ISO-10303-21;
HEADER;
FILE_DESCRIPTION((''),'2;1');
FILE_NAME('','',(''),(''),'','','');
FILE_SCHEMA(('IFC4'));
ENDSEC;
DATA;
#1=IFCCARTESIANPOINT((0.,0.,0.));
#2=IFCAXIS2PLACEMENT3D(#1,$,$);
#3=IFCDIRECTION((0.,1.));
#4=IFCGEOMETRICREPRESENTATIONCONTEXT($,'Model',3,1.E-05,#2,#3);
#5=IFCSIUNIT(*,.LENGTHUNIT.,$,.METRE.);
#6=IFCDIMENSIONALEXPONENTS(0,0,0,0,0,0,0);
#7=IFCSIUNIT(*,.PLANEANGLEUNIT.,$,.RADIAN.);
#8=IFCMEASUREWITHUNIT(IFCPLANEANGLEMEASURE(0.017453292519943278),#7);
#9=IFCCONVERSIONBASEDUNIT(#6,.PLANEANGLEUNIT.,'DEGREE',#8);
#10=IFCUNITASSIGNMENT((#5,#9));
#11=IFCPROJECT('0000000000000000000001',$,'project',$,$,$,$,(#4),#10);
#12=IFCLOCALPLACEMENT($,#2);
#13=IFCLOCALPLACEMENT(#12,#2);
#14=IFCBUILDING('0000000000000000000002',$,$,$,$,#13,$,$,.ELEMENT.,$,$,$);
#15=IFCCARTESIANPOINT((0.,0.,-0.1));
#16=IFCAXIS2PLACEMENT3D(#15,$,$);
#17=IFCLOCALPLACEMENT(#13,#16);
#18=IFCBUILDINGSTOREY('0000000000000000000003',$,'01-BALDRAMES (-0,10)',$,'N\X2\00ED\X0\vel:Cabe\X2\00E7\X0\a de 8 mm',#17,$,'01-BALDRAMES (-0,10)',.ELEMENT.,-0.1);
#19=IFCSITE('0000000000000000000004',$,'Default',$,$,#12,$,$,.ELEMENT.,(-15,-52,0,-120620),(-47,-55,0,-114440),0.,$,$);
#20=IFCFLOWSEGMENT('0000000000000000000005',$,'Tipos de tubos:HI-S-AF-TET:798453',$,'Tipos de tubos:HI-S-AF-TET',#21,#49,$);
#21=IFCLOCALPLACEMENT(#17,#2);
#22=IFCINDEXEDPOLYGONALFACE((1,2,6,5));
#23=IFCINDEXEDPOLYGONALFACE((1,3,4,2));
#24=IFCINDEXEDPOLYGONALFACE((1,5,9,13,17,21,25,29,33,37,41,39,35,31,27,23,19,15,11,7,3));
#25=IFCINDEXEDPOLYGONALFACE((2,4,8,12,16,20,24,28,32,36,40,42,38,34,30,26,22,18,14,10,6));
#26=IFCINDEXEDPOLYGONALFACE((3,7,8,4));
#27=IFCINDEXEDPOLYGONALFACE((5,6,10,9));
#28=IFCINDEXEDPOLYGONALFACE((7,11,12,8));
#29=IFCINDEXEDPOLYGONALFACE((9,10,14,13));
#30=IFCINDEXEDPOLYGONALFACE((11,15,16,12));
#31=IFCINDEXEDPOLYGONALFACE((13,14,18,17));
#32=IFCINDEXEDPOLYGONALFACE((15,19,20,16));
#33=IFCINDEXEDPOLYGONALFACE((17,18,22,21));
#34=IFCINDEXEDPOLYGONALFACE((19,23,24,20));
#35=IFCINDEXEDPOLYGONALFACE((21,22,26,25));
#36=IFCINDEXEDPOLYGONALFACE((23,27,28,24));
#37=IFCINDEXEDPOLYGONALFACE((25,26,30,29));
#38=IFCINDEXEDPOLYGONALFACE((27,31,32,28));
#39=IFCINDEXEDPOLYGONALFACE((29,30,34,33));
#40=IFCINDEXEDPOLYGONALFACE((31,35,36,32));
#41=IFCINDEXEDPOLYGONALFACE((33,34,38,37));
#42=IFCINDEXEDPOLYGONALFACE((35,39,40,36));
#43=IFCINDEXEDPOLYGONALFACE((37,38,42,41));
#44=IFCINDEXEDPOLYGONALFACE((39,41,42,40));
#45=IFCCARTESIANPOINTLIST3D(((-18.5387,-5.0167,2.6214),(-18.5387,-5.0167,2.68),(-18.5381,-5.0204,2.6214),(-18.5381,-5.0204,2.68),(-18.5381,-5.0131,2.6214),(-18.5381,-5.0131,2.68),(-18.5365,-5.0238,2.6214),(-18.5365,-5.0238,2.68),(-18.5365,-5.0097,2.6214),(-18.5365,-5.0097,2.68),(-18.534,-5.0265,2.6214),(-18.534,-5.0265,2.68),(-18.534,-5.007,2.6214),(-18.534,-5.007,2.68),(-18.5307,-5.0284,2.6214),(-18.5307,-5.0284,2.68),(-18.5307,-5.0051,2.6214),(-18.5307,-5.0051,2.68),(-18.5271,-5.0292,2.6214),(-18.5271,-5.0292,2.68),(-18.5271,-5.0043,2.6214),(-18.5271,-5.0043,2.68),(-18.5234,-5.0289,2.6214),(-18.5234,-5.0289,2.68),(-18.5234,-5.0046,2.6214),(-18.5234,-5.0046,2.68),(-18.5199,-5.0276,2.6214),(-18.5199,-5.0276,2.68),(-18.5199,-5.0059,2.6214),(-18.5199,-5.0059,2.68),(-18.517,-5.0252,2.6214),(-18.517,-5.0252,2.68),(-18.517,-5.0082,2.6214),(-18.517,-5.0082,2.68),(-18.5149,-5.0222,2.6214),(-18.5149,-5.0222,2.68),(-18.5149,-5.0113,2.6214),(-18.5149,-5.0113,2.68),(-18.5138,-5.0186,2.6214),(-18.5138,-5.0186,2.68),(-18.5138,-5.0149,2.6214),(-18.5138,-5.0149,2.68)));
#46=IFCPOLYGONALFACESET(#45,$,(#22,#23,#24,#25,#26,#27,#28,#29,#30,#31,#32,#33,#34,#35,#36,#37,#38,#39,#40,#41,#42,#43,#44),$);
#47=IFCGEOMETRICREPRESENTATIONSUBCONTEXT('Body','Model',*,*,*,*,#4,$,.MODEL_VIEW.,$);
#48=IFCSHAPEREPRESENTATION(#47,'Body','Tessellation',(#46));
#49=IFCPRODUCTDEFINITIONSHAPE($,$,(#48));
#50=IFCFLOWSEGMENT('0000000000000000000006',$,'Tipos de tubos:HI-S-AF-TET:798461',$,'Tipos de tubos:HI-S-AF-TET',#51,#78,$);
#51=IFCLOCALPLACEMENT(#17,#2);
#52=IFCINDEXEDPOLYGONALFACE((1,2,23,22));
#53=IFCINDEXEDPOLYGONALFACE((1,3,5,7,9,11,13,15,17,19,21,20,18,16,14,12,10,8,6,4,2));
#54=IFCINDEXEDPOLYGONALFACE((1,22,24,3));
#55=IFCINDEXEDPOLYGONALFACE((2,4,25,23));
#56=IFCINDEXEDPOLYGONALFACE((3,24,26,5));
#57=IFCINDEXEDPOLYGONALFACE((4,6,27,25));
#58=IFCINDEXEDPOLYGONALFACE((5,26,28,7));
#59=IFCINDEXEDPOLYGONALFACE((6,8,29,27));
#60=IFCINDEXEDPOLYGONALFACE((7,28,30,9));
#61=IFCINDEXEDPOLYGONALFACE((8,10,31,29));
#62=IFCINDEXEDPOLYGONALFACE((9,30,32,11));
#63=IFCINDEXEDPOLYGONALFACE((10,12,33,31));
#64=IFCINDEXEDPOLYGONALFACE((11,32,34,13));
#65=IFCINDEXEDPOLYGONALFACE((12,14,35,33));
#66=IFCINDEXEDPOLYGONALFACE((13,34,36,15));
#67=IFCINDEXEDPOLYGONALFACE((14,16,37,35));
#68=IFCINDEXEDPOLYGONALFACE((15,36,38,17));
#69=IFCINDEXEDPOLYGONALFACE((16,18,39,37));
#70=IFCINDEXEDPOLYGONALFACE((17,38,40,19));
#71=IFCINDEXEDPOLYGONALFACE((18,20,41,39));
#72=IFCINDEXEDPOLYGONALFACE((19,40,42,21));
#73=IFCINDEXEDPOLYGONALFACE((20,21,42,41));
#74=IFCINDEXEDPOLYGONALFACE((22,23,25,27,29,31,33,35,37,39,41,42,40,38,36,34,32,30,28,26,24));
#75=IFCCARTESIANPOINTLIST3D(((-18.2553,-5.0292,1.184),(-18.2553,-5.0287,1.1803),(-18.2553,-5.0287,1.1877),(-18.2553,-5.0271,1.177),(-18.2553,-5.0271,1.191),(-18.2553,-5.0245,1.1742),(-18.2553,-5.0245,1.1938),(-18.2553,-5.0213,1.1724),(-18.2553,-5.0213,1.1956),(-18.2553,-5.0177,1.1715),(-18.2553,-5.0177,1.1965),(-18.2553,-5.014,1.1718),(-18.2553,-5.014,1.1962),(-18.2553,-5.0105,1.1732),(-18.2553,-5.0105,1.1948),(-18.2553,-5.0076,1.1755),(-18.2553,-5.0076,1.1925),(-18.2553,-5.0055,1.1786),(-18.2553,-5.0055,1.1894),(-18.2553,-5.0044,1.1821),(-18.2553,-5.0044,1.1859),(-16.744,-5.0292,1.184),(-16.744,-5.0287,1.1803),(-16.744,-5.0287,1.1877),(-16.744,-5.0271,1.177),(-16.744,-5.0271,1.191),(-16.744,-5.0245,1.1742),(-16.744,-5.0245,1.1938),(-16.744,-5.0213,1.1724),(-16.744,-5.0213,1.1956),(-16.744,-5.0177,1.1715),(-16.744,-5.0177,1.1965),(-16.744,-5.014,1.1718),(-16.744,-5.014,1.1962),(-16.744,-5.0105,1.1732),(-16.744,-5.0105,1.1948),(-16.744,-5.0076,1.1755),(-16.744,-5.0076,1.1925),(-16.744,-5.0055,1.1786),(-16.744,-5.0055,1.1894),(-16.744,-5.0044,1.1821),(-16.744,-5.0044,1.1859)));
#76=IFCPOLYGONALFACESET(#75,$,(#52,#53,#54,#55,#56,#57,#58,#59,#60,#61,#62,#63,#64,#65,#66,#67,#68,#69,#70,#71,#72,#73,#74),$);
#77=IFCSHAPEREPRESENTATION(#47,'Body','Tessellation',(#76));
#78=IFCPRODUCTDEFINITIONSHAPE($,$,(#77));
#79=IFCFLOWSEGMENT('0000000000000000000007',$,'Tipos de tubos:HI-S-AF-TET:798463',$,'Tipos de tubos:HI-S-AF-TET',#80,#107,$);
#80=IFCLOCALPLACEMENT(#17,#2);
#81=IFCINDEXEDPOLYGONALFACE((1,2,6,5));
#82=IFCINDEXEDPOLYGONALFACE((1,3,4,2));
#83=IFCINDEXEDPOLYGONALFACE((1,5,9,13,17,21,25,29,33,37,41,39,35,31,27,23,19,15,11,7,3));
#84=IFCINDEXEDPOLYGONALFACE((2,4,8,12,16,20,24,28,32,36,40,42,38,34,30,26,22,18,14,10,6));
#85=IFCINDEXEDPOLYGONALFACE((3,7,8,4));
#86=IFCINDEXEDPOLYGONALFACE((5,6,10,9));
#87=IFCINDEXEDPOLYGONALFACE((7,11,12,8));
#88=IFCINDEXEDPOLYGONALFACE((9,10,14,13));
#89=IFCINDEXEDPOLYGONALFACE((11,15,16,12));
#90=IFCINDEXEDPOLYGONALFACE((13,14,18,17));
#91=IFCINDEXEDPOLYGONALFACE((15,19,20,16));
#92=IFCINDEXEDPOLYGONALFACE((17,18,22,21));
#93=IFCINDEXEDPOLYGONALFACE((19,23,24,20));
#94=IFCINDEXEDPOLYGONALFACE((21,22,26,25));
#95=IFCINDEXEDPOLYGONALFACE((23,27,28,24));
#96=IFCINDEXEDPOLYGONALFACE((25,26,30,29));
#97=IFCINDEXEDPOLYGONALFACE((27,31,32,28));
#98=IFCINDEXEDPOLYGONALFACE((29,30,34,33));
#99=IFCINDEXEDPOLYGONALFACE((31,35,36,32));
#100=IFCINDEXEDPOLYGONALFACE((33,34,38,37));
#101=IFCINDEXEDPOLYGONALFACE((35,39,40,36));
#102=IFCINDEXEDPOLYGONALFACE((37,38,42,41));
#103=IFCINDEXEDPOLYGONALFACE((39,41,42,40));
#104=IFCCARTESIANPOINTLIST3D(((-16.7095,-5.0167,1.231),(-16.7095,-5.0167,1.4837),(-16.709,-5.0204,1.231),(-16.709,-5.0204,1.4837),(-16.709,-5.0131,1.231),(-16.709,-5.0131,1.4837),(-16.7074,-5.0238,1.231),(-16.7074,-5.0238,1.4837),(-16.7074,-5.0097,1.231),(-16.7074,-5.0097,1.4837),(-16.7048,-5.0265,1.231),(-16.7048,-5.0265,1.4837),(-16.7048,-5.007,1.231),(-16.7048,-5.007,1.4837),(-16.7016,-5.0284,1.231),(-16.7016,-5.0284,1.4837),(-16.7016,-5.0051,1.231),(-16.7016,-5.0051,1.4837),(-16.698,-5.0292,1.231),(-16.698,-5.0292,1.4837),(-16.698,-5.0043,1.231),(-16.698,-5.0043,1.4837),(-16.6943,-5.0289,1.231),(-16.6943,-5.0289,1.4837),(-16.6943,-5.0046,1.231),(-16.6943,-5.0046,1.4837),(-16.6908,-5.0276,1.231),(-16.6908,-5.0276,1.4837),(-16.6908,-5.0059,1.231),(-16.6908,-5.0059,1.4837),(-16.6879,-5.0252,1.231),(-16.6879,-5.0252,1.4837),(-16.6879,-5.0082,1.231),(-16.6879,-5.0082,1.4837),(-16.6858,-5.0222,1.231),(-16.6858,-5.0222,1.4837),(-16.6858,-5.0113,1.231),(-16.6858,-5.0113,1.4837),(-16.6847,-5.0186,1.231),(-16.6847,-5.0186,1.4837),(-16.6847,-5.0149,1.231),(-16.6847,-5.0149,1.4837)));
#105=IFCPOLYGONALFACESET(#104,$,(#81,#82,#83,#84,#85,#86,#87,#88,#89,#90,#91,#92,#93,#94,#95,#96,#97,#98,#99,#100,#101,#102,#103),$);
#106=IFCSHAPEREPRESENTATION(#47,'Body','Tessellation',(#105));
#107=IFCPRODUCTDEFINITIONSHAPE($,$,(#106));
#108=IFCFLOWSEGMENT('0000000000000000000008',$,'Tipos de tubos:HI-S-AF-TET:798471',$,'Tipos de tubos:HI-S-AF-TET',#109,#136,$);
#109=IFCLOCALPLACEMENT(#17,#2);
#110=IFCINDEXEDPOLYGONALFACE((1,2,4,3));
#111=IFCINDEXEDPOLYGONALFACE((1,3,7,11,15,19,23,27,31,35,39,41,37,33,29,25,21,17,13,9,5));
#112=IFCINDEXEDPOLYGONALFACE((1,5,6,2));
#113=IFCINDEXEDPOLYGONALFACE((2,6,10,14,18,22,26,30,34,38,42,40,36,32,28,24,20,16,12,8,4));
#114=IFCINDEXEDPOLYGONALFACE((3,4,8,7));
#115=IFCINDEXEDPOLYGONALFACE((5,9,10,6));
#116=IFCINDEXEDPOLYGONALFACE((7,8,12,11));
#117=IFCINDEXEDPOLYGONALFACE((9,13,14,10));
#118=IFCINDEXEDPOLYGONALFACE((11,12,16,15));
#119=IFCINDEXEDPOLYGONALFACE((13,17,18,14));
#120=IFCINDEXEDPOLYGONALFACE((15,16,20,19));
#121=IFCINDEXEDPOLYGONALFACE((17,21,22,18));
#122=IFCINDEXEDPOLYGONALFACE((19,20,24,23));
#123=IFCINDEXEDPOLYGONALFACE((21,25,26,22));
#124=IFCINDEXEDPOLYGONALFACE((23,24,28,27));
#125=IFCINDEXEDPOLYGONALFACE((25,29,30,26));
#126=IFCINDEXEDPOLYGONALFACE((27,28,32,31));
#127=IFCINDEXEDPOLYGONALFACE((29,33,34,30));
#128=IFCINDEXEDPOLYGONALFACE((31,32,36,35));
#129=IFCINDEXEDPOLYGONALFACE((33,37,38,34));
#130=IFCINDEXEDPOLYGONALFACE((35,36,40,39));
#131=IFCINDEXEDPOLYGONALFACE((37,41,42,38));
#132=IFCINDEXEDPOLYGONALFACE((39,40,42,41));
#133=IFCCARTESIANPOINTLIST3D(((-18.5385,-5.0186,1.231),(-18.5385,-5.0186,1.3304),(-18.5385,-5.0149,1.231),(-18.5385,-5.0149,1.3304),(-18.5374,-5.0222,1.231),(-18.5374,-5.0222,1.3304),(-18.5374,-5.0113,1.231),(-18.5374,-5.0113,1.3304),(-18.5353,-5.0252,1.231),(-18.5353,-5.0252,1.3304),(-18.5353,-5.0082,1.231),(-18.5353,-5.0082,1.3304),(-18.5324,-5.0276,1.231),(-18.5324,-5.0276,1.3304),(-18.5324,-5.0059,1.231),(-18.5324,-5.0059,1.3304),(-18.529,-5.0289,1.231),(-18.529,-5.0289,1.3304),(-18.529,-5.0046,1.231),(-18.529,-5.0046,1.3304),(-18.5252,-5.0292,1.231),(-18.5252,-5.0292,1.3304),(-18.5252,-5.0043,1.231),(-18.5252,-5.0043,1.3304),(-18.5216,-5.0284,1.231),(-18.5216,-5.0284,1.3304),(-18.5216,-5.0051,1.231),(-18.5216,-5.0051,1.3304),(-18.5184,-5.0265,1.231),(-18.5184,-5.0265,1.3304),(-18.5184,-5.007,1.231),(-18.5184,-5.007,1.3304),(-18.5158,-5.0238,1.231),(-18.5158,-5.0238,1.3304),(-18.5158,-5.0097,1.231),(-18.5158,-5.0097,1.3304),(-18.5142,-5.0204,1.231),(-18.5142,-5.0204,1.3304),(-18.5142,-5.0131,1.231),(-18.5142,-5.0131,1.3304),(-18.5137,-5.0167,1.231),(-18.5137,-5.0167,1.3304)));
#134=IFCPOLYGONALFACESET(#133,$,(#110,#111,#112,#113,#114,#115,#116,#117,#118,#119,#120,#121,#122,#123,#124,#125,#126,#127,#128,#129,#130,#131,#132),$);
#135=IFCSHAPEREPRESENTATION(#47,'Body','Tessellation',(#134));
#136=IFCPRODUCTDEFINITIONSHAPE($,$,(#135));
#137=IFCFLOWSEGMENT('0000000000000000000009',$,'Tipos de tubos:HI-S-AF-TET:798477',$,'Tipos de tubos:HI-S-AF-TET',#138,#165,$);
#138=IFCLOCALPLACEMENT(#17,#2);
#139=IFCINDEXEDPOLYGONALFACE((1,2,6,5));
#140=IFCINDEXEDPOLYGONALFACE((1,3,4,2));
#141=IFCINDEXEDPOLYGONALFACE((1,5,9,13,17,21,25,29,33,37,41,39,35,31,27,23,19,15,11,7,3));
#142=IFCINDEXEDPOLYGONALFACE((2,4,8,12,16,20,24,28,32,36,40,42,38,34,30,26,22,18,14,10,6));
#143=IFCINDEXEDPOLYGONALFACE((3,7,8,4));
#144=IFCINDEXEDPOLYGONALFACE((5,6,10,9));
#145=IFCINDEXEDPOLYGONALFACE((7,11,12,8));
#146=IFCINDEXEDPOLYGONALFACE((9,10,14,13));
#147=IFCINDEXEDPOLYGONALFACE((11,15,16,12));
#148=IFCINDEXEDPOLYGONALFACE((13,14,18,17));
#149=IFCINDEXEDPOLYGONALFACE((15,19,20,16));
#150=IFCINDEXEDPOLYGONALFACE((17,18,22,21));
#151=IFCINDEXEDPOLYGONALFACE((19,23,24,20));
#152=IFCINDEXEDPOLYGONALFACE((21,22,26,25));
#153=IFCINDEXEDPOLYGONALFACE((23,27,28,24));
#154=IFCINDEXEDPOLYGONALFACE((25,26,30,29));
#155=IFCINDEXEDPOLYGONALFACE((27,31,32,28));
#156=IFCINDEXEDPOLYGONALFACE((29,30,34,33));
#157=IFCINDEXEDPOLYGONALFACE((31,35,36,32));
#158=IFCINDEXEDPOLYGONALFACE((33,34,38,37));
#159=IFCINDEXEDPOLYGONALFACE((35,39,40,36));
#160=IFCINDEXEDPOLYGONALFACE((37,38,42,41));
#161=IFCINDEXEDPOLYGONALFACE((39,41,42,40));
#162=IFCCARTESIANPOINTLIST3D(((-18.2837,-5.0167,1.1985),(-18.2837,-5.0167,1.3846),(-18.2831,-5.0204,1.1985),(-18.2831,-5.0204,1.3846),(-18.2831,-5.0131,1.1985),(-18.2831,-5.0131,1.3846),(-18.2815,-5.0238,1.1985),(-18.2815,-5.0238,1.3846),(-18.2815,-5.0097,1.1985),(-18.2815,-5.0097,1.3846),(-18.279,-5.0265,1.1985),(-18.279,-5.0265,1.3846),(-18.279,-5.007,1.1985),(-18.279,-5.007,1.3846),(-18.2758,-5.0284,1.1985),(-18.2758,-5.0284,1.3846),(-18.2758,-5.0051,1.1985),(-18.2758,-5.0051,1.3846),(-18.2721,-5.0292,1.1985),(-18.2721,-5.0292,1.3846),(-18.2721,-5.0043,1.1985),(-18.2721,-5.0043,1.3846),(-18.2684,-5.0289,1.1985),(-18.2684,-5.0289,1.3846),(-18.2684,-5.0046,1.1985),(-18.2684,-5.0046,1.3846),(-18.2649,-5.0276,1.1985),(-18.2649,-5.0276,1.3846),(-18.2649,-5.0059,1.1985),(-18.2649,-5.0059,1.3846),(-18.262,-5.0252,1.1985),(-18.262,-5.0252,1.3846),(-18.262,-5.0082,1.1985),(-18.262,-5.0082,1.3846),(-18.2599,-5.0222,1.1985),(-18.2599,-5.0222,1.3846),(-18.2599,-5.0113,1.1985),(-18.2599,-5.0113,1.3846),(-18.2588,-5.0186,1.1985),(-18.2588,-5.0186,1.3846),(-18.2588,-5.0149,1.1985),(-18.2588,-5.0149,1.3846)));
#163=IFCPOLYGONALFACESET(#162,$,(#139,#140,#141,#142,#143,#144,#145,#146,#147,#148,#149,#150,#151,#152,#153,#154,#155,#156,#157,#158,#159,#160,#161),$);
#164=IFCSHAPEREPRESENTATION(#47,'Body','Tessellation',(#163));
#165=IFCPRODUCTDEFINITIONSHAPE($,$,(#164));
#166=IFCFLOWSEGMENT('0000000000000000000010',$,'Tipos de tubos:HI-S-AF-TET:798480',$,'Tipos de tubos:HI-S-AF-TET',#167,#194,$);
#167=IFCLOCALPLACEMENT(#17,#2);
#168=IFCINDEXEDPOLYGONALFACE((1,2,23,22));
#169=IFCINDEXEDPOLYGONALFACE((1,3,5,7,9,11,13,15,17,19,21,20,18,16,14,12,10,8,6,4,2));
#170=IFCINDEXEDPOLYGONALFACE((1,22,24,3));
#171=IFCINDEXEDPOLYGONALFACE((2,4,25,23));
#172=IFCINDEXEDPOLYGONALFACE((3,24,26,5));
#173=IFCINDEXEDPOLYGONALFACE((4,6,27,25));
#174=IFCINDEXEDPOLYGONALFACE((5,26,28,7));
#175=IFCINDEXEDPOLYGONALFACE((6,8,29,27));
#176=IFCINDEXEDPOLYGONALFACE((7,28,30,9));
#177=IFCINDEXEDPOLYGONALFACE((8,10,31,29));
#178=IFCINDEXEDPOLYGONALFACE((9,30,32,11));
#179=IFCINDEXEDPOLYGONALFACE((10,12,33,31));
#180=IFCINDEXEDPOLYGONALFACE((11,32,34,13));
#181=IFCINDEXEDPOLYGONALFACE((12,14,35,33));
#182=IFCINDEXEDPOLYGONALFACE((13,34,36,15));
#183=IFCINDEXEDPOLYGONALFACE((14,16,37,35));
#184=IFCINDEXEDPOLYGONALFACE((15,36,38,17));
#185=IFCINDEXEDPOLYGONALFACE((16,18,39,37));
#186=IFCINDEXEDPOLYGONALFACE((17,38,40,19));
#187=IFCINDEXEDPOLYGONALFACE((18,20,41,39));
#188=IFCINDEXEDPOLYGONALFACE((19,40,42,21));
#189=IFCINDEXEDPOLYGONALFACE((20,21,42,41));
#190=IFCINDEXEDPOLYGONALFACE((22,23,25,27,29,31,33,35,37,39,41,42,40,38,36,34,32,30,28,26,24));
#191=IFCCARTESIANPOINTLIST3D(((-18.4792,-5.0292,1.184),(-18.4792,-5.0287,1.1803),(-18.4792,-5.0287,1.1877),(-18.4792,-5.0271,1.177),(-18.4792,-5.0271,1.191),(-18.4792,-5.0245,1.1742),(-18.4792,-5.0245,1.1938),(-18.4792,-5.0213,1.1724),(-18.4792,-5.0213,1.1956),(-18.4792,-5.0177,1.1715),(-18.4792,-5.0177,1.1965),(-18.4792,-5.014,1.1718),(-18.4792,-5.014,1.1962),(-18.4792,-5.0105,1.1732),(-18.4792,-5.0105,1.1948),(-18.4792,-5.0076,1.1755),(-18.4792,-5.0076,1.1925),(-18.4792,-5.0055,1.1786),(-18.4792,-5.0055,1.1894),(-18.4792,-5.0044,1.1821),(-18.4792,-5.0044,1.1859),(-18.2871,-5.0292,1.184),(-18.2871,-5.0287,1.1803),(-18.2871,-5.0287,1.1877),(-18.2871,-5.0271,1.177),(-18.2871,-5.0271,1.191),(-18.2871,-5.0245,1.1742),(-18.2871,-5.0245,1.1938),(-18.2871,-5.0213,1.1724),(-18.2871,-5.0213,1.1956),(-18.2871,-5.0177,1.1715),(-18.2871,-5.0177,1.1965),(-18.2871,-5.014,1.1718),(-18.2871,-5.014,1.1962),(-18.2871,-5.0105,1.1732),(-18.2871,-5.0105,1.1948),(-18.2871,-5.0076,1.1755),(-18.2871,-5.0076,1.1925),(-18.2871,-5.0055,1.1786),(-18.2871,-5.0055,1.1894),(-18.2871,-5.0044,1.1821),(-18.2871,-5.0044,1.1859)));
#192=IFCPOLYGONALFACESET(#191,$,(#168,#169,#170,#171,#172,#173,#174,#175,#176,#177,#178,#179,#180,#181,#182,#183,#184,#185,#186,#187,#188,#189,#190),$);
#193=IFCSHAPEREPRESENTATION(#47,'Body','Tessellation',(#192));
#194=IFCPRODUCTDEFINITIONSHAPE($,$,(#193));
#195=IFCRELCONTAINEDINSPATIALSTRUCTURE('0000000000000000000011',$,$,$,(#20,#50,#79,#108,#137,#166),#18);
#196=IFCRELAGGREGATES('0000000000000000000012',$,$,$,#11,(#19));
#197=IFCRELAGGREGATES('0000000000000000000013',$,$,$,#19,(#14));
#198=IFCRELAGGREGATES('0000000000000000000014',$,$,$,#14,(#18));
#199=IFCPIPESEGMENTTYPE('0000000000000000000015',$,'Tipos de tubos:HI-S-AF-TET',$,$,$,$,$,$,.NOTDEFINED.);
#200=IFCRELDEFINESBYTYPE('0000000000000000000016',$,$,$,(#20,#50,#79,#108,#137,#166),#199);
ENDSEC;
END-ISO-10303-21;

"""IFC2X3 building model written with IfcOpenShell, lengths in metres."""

from ifc_helpers import new_model, entity, si_unit, converted_unit, direction, frame, frame_2d, origin, origin_2d_with_axis, place, context, subcontext, project, spatial, circle, extrude, type_object, element, save


model = new_model("IFC2X3")

# Units and contexts
model_context = context("Model", 3, precision=1e-05, world=origin(), true_north=direction((0.0, 1.0)))
body_context = subcontext(model_context, "Body", "Model", "MODEL_VIEW")
ifc_project = project(units=[si_unit("LENGTHUNIT", "METRE"), converted_unit("PLANEANGLEUNIT", "DEGREE", entity("IfcPlaneAngleMeasure", 0.017453292519943278), si_unit("PLANEANGLEUNIT", "RADIAN"), dimensions=[0, 0, 0, 0, 0, 0, 0])], contexts=[model_context])

# Site, building, storey
site_placement = place(None, origin())
site = spatial("IfcSite", under=ifc_project, at=site_placement, Name="Default", CompositionType="ELEMENT", RefLatitude=(-15, -52, 0, -120620), RefLongitude=(-47, -55, 0, -114440), RefElevation=0.0)
building_placement = place(site_placement, origin())
building = spatial("IfcBuilding", under=site, at=building_placement, CompositionType="ELEMENT")
storey_placement = place(building_placement, frame((0.0, 0.0, -0.1)))
storey = spatial("IfcBuildingStorey", under=building, at=storey_placement, Name="01-BALDRAMES (-0,10)", ObjectType="Nível:Cabeça de 8 mm", LongName="01-BALDRAMES (-0,10)", CompositionType="ELEMENT", Elevation=-0.1)

# Flow segments
pipe_segment_type_1 = type_object("IfcPipeSegmentType", Name="Tipos de tubos:HI-S-AF-TET", PredefinedType="NOTDEFINED")
flow_segment_1_placement = place(storey_placement, origin())
element("IfcFlowSegment", 1, at=flow_segment_1_placement, inside=storey, type_object=pipe_segment_type_1, Name="Tipos de tubos:HI-S-AF-TET:798453", ObjectType="Tipos de tubos:HI-S-AF-TET", context=body_context, shape_type="SweptSolid", body=[
    extrude(circle(Radius=0.0125, at=frame_2d((0.0, 0.0), x_axis=(1.0, 0.0))), frame((-18.5262, -5.0167, 2.6214), z_axis=(0.0, 0.0, 1.0), x_axis=(-1.0, 0.0, 0.0)), (0.0, 0.0, 1.0), 0.0586),
])
flow_segment_2_placement = place(storey_placement, origin())
element("IfcFlowSegment", 2, at=flow_segment_2_placement, inside=storey, type_object=pipe_segment_type_1, Name="Tipos de tubos:HI-S-AF-TET:798461", ObjectType="Tipos de tubos:HI-S-AF-TET", context=body_context, shape_type="SweptSolid", body=[
    extrude(circle(Radius=0.0125, at=frame_2d((0.0, 0.0), x_axis=(1.0, 0.0))), frame((-18.2553, -5.0167, 1.184), z_axis=(1.0, 0.000003, 0.0), x_axis=(0.000003, -1.0, 0.0)), (0.0, 0.0, 1.0), 1.5113),
])
flow_segment_3_placement = place(storey_placement, origin())
element("IfcFlowSegment", 3, at=flow_segment_3_placement, inside=storey, type_object=pipe_segment_type_1, Name="Tipos de tubos:HI-S-AF-TET:798463", ObjectType="Tipos de tubos:HI-S-AF-TET", context=body_context, shape_type="SweptSolid", body=[
    extrude(circle(Radius=0.0125, at=frame_2d((0.0, 0.0), x_axis=(1.0, 0.0))), frame((-16.697, -5.0167, 1.231), z_axis=(0.0, 0.0, 1.0), x_axis=(-1.0, 0.0, 0.0)), (0.0, 0.0, 1.0), 0.2527),
])
flow_segment_4_placement = place(storey_placement, origin())
element("IfcFlowSegment", 4, at=flow_segment_4_placement, inside=storey, type_object=pipe_segment_type_1, Name="Tipos de tubos:HI-S-AF-TET:798471", ObjectType="Tipos de tubos:HI-S-AF-TET", context=body_context, shape_type="SweptSolid", body=[
    extrude(circle(Radius=0.0125, at=origin_2d_with_axis()), frame((-18.5262, -5.0167, 1.231)), (0.0, 0.0, 1.0), 0.0994),
])
flow_segment_5_placement = place(storey_placement, origin())
element("IfcFlowSegment", 5, at=flow_segment_5_placement, inside=storey, type_object=pipe_segment_type_1, Name="Tipos de tubos:HI-S-AF-TET:798477", ObjectType="Tipos de tubos:HI-S-AF-TET", context=body_context, shape_type="SweptSolid", body=[
    extrude(circle(Radius=0.0125, at=origin_2d_with_axis()), frame((-18.2712, -5.0167, 1.1985), z_axis=(0.0, 0.0, 1.0), x_axis=(-1.0, 0.0, 0.0)), (0.0, 0.0, 1.0), 0.1861),
])
flow_segment_6_placement = place(storey_placement, origin())
element("IfcFlowSegment", 6, at=flow_segment_6_placement, inside=storey, type_object=pipe_segment_type_1, Name="Tipos de tubos:HI-S-AF-TET:798480", ObjectType="Tipos de tubos:HI-S-AF-TET", context=body_context, shape_type="SweptSolid", body=[
    extrude(circle(Radius=0.0125, at=frame_2d((0.0, 0.0), x_axis=(1.0, 0.0))), frame((-18.4792, -5.0167, 1.184), z_axis=(1.0, 0.000004, 0.0), x_axis=(0.000004, -1.0, 0.0)), (0.0, 0.0, 1.0), 0.1921),
])

save(model, "model.ifc")
